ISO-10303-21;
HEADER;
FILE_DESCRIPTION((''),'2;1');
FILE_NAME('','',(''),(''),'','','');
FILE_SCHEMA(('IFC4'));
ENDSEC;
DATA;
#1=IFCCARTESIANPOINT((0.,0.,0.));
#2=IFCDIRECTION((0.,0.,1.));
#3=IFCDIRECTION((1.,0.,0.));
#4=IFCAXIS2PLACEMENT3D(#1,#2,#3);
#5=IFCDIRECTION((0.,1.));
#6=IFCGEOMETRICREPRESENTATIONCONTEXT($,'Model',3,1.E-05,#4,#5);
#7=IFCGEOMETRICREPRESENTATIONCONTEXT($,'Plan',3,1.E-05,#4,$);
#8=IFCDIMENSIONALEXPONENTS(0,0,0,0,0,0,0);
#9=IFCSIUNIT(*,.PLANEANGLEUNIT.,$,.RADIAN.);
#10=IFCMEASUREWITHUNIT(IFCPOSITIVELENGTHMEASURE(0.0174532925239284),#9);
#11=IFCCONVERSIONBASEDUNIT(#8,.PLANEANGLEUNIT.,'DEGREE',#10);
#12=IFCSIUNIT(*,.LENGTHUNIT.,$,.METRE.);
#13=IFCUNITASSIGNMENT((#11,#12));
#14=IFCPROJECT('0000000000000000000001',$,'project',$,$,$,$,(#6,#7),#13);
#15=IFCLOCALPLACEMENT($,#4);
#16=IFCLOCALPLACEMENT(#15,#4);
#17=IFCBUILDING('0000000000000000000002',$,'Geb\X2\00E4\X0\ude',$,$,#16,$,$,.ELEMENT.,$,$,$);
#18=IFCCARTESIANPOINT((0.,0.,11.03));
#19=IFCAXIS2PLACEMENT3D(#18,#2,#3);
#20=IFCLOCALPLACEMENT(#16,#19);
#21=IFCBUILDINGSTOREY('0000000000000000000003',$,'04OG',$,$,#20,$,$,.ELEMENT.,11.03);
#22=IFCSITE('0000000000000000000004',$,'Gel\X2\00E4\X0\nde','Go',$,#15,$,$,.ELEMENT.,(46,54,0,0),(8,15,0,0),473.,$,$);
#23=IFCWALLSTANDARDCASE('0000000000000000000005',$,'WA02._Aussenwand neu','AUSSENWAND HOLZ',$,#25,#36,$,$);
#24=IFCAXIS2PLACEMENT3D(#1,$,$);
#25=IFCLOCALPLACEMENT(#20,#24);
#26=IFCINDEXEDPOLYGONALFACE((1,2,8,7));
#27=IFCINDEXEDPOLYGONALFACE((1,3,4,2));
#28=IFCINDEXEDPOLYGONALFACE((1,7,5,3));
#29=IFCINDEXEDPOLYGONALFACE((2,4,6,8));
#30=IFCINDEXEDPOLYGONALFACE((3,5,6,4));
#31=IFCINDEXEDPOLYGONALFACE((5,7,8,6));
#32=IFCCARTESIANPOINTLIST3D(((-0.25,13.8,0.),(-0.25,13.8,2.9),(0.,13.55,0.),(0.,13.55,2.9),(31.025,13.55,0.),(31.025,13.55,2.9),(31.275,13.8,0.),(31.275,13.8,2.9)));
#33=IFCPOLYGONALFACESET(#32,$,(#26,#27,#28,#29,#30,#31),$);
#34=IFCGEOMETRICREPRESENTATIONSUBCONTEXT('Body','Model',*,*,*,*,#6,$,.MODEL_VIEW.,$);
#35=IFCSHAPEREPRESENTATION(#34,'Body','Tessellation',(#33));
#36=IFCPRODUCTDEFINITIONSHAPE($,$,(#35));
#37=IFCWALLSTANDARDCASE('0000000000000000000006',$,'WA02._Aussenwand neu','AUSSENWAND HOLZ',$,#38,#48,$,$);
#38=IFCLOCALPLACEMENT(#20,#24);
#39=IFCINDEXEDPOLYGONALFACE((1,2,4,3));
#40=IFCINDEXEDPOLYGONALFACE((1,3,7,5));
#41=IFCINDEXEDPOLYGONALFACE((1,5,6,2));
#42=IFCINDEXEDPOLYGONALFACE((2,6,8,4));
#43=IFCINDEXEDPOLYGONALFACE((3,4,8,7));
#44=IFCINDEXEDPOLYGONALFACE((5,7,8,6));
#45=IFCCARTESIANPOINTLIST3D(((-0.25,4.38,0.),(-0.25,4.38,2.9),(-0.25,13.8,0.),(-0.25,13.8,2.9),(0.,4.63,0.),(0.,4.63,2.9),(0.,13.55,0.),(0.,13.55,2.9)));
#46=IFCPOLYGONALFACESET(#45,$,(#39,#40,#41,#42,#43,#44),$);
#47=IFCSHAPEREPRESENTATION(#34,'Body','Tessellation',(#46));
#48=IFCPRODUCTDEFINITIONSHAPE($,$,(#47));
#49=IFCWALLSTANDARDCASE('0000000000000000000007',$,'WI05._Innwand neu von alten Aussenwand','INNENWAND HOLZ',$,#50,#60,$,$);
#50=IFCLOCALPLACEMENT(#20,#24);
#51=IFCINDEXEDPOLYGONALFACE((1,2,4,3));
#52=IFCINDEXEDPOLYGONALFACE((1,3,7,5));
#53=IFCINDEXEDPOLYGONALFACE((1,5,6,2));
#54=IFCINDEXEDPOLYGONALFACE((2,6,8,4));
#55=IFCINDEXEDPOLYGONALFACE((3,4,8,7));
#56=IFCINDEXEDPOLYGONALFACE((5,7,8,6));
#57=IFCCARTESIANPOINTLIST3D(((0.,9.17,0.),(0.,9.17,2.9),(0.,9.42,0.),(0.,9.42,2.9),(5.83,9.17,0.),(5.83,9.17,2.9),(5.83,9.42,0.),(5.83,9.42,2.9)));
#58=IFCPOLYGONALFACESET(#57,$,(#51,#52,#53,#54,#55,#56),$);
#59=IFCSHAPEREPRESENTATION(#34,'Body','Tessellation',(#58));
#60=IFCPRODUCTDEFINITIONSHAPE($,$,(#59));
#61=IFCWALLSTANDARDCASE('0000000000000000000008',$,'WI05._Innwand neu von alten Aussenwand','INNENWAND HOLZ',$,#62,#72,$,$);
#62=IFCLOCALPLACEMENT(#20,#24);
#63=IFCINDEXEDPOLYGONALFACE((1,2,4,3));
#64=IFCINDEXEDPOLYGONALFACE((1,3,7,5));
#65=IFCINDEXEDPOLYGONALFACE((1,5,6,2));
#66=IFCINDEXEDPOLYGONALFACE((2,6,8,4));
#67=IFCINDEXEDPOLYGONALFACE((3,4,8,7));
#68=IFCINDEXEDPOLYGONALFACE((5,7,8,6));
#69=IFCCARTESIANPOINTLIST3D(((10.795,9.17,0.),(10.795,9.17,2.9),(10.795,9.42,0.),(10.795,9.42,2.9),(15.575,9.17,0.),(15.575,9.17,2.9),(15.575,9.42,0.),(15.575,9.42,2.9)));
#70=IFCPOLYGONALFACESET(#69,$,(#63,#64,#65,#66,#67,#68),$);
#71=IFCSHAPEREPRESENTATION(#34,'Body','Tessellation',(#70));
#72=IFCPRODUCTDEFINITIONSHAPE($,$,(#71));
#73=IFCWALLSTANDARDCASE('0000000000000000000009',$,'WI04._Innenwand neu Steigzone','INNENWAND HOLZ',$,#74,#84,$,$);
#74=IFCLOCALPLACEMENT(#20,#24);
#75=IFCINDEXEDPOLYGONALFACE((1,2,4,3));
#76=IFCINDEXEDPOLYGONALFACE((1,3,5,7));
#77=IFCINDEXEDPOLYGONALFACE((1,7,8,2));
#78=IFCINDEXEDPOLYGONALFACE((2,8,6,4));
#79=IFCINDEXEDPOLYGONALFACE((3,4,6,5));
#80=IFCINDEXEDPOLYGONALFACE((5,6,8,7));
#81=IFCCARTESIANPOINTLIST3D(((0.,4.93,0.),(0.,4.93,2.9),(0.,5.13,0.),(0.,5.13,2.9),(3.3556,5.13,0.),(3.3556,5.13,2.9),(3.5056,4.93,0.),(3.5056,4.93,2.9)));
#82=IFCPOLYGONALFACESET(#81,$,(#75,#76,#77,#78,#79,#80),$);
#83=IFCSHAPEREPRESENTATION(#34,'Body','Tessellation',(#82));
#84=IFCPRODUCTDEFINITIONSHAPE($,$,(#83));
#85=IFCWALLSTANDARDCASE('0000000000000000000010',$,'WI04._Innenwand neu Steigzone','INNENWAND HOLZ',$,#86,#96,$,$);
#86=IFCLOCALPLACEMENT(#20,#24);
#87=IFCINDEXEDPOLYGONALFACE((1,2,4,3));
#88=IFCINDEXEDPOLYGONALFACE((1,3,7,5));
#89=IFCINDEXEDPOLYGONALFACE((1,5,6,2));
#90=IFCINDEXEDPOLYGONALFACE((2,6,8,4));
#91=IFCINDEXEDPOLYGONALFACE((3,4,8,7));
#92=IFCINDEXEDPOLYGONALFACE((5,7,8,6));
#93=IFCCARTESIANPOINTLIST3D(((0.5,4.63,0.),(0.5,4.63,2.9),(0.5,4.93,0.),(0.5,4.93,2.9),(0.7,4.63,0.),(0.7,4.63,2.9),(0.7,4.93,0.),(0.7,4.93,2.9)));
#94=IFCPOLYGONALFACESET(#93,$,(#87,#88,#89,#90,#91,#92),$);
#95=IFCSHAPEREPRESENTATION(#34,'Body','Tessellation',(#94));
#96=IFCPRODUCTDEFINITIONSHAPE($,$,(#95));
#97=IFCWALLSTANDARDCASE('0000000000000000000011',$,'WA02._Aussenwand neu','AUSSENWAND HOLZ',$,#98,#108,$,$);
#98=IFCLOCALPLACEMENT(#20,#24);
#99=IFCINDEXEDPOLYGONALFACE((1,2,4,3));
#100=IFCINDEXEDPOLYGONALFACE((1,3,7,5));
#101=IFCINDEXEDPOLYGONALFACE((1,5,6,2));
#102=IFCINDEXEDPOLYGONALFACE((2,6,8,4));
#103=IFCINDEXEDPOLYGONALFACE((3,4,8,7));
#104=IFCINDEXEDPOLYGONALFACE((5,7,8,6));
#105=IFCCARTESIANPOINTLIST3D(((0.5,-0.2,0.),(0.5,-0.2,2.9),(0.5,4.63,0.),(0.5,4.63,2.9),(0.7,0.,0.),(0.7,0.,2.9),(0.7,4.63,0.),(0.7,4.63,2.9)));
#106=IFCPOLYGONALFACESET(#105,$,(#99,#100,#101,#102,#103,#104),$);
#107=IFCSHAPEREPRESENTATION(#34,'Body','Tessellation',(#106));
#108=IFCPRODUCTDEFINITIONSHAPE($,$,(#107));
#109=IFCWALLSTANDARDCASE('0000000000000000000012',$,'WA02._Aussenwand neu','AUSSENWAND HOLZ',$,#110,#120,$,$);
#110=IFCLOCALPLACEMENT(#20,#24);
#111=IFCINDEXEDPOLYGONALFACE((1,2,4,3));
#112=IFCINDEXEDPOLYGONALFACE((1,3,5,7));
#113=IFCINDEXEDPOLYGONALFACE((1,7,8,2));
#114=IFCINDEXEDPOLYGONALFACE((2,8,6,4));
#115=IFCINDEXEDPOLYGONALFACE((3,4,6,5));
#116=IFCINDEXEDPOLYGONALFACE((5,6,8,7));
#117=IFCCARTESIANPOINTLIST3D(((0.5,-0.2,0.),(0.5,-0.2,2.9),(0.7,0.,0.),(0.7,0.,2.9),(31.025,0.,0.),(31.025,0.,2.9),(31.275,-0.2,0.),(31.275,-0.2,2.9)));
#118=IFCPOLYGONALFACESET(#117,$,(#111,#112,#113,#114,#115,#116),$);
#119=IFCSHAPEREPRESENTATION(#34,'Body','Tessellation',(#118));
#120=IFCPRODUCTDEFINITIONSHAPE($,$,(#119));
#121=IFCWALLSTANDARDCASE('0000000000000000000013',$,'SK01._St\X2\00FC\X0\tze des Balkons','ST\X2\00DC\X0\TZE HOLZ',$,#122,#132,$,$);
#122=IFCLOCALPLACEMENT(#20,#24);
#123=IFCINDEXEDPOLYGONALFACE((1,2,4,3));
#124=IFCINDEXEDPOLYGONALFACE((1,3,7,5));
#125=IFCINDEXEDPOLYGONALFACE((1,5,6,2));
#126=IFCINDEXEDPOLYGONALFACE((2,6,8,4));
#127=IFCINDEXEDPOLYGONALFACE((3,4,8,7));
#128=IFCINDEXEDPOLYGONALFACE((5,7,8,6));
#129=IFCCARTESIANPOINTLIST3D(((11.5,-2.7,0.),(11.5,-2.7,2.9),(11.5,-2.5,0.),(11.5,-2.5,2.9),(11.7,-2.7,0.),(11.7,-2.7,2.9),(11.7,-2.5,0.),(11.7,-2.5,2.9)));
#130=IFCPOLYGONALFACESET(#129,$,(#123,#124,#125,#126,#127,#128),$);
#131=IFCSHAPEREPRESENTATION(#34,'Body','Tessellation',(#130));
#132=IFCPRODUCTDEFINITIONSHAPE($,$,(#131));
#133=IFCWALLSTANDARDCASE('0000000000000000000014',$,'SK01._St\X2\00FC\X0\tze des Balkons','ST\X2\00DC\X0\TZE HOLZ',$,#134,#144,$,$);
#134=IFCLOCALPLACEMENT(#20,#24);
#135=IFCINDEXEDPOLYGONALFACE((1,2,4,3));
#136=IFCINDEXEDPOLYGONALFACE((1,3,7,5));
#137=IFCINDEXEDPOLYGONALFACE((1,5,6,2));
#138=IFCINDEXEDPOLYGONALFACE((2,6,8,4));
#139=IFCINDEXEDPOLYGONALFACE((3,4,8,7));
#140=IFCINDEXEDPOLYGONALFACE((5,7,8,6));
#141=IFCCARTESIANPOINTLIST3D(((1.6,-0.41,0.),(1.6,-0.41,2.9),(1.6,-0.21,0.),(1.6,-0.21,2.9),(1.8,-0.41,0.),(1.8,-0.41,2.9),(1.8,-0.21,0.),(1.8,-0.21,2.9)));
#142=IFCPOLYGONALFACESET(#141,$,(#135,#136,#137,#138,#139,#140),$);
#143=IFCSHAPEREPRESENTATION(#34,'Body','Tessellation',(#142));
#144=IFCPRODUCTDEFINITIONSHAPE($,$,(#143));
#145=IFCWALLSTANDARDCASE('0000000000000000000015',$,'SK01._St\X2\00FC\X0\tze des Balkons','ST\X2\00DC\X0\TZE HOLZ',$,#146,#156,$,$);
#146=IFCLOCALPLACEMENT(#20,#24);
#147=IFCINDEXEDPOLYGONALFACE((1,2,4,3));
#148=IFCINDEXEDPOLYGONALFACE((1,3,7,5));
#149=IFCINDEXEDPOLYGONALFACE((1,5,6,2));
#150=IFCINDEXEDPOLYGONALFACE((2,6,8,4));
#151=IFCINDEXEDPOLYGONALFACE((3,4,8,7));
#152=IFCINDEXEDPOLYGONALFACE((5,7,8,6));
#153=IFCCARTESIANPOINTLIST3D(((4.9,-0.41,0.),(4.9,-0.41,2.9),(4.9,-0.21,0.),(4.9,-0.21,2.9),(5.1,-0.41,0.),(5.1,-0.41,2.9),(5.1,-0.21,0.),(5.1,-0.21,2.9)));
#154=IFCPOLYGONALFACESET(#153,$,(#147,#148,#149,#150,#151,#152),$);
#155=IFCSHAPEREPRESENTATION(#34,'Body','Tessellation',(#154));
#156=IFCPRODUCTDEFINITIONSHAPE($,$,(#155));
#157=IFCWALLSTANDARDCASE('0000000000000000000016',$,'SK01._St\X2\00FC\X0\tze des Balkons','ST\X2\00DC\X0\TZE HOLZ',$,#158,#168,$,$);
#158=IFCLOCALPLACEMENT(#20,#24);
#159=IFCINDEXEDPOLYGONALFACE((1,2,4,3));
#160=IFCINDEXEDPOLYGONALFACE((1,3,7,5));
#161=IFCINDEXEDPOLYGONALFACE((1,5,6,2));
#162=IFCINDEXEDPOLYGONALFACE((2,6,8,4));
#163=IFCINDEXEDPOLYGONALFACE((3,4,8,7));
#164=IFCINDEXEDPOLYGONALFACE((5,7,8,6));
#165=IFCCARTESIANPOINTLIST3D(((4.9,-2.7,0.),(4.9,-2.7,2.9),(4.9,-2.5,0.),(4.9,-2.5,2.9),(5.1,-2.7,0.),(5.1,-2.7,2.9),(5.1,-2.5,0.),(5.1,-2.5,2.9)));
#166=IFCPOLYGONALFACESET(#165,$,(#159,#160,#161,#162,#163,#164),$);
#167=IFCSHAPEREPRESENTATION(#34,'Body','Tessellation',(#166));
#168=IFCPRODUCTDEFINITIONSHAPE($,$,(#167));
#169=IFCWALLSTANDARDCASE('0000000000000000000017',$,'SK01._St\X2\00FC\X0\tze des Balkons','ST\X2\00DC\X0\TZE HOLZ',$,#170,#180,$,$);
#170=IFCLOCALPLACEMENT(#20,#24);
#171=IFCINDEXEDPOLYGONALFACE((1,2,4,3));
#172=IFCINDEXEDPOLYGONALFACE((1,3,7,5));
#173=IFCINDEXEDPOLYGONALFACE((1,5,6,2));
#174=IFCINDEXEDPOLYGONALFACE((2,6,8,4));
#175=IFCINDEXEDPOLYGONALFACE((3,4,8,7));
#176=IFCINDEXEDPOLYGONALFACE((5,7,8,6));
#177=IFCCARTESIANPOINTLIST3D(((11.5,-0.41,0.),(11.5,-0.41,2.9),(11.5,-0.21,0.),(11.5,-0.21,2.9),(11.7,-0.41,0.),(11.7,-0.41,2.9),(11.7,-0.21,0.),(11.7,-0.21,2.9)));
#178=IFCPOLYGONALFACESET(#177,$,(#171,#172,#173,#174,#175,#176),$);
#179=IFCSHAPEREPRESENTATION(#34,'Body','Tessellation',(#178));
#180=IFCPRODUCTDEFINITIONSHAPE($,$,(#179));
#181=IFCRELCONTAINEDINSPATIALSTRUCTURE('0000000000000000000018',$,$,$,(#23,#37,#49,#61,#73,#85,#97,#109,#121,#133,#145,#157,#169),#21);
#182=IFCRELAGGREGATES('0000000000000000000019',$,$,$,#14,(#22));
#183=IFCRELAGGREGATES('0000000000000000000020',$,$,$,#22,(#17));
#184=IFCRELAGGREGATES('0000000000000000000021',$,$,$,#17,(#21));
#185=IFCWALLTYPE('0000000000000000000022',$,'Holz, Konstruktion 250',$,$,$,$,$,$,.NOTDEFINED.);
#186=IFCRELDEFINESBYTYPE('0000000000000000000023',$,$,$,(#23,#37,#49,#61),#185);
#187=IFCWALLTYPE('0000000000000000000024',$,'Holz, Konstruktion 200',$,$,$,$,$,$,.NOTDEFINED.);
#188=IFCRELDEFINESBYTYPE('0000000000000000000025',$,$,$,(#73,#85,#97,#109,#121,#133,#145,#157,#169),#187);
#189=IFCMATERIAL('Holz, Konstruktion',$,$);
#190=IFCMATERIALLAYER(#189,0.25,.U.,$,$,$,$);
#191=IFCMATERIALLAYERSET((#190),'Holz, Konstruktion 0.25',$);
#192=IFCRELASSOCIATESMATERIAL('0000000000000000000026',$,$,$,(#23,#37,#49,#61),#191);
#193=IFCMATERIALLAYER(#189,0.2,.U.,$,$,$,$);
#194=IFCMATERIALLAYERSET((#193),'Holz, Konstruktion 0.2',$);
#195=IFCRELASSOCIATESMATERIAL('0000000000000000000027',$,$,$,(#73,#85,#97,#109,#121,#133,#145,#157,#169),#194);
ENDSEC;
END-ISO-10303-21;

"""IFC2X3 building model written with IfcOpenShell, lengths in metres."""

from ifc_helpers import new_model, entity, si_unit, converted_unit, direction, frame, origin_with_axes, place, context, subcontext, project, spatial, polyline, outline, extrude, material, layer, layer_set, layer_usage, type_object, element, save


model = new_model("IFC2X3")

# Units and contexts
model_context = context("Model", 3, precision=1e-05, world=origin_with_axes(), true_north=direction((0.0, 1.0)))
plan_context = context("Plan", 3, precision=1e-05, world=origin_with_axes())
body_context = subcontext(model_context, "Body", "Model", "MODEL_VIEW")
ifc_project = project(units=[converted_unit("PLANEANGLEUNIT", "DEGREE", entity("IfcPositiveLengthMeasure", 0.0174532925239284), si_unit("PLANEANGLEUNIT", "RADIAN"), dimensions=[0, 0, 0, 0, 0, 0, 0]), si_unit("LENGTHUNIT", "METRE")], contexts=[model_context, plan_context])

# Site, building, storey
site_placement = place(None, origin_with_axes())
site = spatial("IfcSite", under=ifc_project, at=site_placement, Name="Gelände", Description="Go", CompositionType="ELEMENT", RefLatitude=(46, 54, 0, 0), RefLongitude=(8, 15, 0, 0), RefElevation=473.0)
building_placement = place(site_placement, origin_with_axes())
building = spatial("IfcBuilding", under=site, at=building_placement, Name="Gebäude", CompositionType="ELEMENT")
storey_placement = place(building_placement, frame((0.0, 0.0, 11.03), z_axis=(0.0, 0.0, 1.0), x_axis=(1.0, 0.0, 0.0)))
storey = spatial("IfcBuildingStorey", under=building, at=storey_placement, Name="04OG", CompositionType="ELEMENT", Elevation=11.03)

# Shared definitions
ifc_material_1 = material(Name="Holz, Konstruktion")

# Walls
ifc_layer_1 = layer(ifc_material_1, 0.25, ventilated="UNKNOWN")
ifc_layer_set_1 = layer_set([ifc_layer_1], Name="Holz, Konstruktion 0.25")
wall_type_1 = type_object("IfcWallType", Name="Holz, Konstruktion 250", PredefinedType="NOTDEFINED")
ifc_layer_usage_1 = layer_usage(ifc_layer_set_1, "AXIS2", "NEGATIVE", 0.0)
wall_1_placement = place(storey_placement, frame((-0.25, 13.8, 0.0), z_axis=(0.0, 0.0, 1.0), x_axis=(1.0, 0.0, 0.0)))
element("IfcWallStandardCase", 1, at=wall_1_placement, inside=storey, type_object=wall_type_1, material=ifc_layer_usage_1, Name="WA02._Aussenwand neu", Description="AUSSENWAND HOLZ", context=body_context, shape_type="SweptSolid", body=[
    extrude(outline(polyline([(0.25, -0.25), (31.275, -0.25), (31.525, 0.0), (0.0, 0.0), (0.25, -0.25)])), origin_with_axes(), (0.0, 0.0, 1.0), 2.9),
])
ifc_layer_usage_2 = layer_usage(ifc_layer_set_1, "AXIS2", "NEGATIVE", 0.0)
wall_2_placement = place(storey_placement, frame((-0.25, 4.38, 0.0), z_axis=(0.0, 0.0, 1.0), x_axis=(0.0, 1.0, 0.0)))
element("IfcWallStandardCase", 2, at=wall_2_placement, inside=storey, type_object=wall_type_1, material=ifc_layer_usage_2, Name="WA02._Aussenwand neu", Description="AUSSENWAND HOLZ", context=body_context, shape_type="SweptSolid", body=[
    extrude(outline(polyline([(0.25, -0.25), (9.17, -0.25), (9.42, 0.0), (0.0, 0.0), (0.25, -0.25)])), origin_with_axes(), (0.0, 0.0, 1.0), 2.9),
])
ifc_layer_usage_3 = layer_usage(ifc_layer_set_1, "AXIS2", "NEGATIVE", 0.0)
wall_3_placement = place(storey_placement, frame((0.0, 9.42, 0.0), z_axis=(0.0, 0.0, 1.0), x_axis=(1.0, 0.0, 0.0)))
element("IfcWallStandardCase", 3, at=wall_3_placement, inside=storey, type_object=wall_type_1, material=ifc_layer_usage_3, Name="WI05._Innwand neu von alten Aussenwand", Description="INNENWAND HOLZ", context=body_context, shape_type="SweptSolid", body=[
    extrude(outline(polyline([(0.0, -0.25), (5.83, -0.25), (5.83, 0.0), (0.0, 0.0), (0.0, -0.25)])), origin_with_axes(), (0.0, 0.0, 1.0), 2.9),
])
ifc_layer_usage_4 = layer_usage(ifc_layer_set_1, "AXIS2", "NEGATIVE", 0.0)
wall_4_placement = place(storey_placement, frame((10.795, 9.42, 0.0), z_axis=(0.0, 0.0, 1.0), x_axis=(1.0, 0.0, 0.0)))
element("IfcWallStandardCase", 4, at=wall_4_placement, inside=storey, type_object=wall_type_1, material=ifc_layer_usage_4, Name="WI05._Innwand neu von alten Aussenwand", Description="INNENWAND HOLZ", context=body_context, shape_type="SweptSolid", body=[
    extrude(outline(polyline([(0.0, -0.25), (4.78, -0.25), (4.78, 0.0), (0.0, 0.0), (0.0, -0.25)])), origin_with_axes(), (0.0, 0.0, 1.0), 2.9),
])
ifc_layer_2 = layer(ifc_material_1, 0.2, ventilated="UNKNOWN")
ifc_layer_set_2 = layer_set([ifc_layer_2], Name="Holz, Konstruktion 0.2")
ifc_layer_usage_5 = layer_usage(ifc_layer_set_2, "AXIS2", "NEGATIVE", 0.0)
wall_type_2 = type_object("IfcWallType", Name="Holz, Konstruktion 200", PredefinedType="NOTDEFINED")
wall_5_placement = place(storey_placement, frame((3.5056, 4.93, 0.0), z_axis=(0.0, 0.0, 1.0), x_axis=(-1.0, 0.0, 0.0)))
element("IfcWallStandardCase", 5, at=wall_5_placement, inside=storey, type_object=wall_type_2, material=ifc_layer_usage_5, Name="WI04._Innenwand neu Steigzone", Description="INNENWAND HOLZ", context=body_context, shape_type="SweptSolid", body=[
    extrude(outline(polyline([(0.15, -0.2), (3.5056, -0.2), (3.5056, 0.0), (0.0, 0.0), (0.15, -0.2)])), origin_with_axes(), (0.0, 0.0, 1.0), 2.9),
])
ifc_layer_usage_6 = layer_usage(ifc_layer_set_2, "AXIS2", "NEGATIVE", 0.0)
wall_6_placement = place(storey_placement, frame((0.7, 4.93, 0.0), z_axis=(0.0, 0.0, 1.0), x_axis=(0.0, -1.0, 0.0)))
element("IfcWallStandardCase", 6, at=wall_6_placement, inside=storey, type_object=wall_type_2, material=ifc_layer_usage_6, Name="WI04._Innenwand neu Steigzone", Description="INNENWAND HOLZ", context=body_context, shape_type="SweptSolid", body=[
    extrude(outline(polyline([(0.0, -0.2), (0.3, -0.2), (0.3, 0.0), (0.0, 0.0), (0.0, -0.2)])), origin_with_axes(), (0.0, 0.0, 1.0), 2.9),
])
ifc_layer_usage_7 = layer_usage(ifc_layer_set_2, "AXIS2", "POSITIVE", 0.0)
wall_7_placement = place(storey_placement, frame((0.5, 4.63, 0.0), z_axis=(0.0, 0.0, 1.0), x_axis=(0.0, -1.0, 0.0)))
element("IfcWallStandardCase", 7, at=wall_7_placement, inside=storey, type_object=wall_type_2, material=ifc_layer_usage_7, Name="WA02._Aussenwand neu", Description="AUSSENWAND HOLZ", context=body_context, shape_type="SweptSolid", body=[
    extrude(outline(polyline([(0.0, 0.0), (4.83, 0.0), (4.63, 0.2), (0.0, 0.2), (0.0, 0.0)])), origin_with_axes(), (0.0, 0.0, 1.0), 2.9),
])
ifc_layer_usage_8 = layer_usage(ifc_layer_set_2, "AXIS2", "POSITIVE", 0.0)
wall_8_placement = place(storey_placement, frame((0.5, -0.2, 0.0), z_axis=(0.0, 0.0, 1.0), x_axis=(1.0, 0.0, 0.0)))
element("IfcWallStandardCase", 8, at=wall_8_placement, inside=storey, type_object=wall_type_2, material=ifc_layer_usage_8, Name="WA02._Aussenwand neu", Description="AUSSENWAND HOLZ", context=body_context, shape_type="SweptSolid", body=[
    extrude(outline(polyline([(0.0, 0.0), (30.775, 0.0), (30.525, 0.2), (0.2, 0.2), (0.0, 0.0)])), origin_with_axes(), (0.0, 0.0, 1.0), 2.9),
])
ifc_layer_usage_9 = layer_usage(ifc_layer_set_2, "AXIS2", "NEGATIVE", 0.0)
wall_9_placement = place(storey_placement, frame((11.5, -2.7, 0.0), z_axis=(0.0, 0.0, 1.0), x_axis=(0.0, 1.0, 0.0)))
element("IfcWallStandardCase", 9, at=wall_9_placement, inside=storey, type_object=wall_type_2, material=ifc_layer_usage_9, Name="SK01._Stütze des Balkons", Description="STÜTZE HOLZ", context=body_context, shape_type="SweptSolid", body=[
    extrude(outline(polyline([(0.0, -0.2), (0.2, -0.2), (0.2, 0.0), (0.0, 0.0), (0.0, -0.2)])), origin_with_axes(), (0.0, 0.0, 1.0), 2.9),
])
ifc_layer_usage_10 = layer_usage(ifc_layer_set_2, "AXIS2", "NEGATIVE", 0.0)
wall_10_placement = place(storey_placement, frame((1.6, -0.41, 0.0), z_axis=(0.0, 0.0, 1.0), x_axis=(0.0, 1.0, 0.0)))
element("IfcWallStandardCase", 10, at=wall_10_placement, inside=storey, type_object=wall_type_2, material=ifc_layer_usage_10, Name="SK01._Stütze des Balkons", Description="STÜTZE HOLZ", context=body_context, shape_type="SweptSolid", body=[
    extrude(outline(polyline([(0.0, -0.2), (0.2, -0.2), (0.2, 0.0), (0.0, 0.0), (0.0, -0.2)])), origin_with_axes(), (0.0, 0.0, 1.0), 2.9),
])
ifc_layer_usage_11 = layer_usage(ifc_layer_set_2, "AXIS2", "POSITIVE", 0.0)
wall_11_placement = place(storey_placement, frame((5.1, -0.41, 0.0), z_axis=(0.0, 0.0, 1.0), x_axis=(0.0, 1.0, 0.0)))
element("IfcWallStandardCase", 11, at=wall_11_placement, inside=storey, type_object=wall_type_2, material=ifc_layer_usage_11, Name="SK01._Stütze des Balkons", Description="STÜTZE HOLZ", context=body_context, shape_type="SweptSolid", body=[
    extrude(outline(polyline([(0.0, 0.0), (0.2, 0.0), (0.2, 0.2), (0.0, 0.2), (0.0, 0.0)])), origin_with_axes(), (0.0, 0.0, 1.0), 2.9),
])
ifc_layer_usage_12 = layer_usage(ifc_layer_set_2, "AXIS2", "POSITIVE", 0.0)
wall_12_placement = place(storey_placement, frame((5.1, -2.7, 0.0), z_axis=(0.0, 0.0, 1.0), x_axis=(0.0, 1.0, 0.0)))
element("IfcWallStandardCase", 12, at=wall_12_placement, inside=storey, type_object=wall_type_2, material=ifc_layer_usage_12, Name="SK01._Stütze des Balkons", Description="STÜTZE HOLZ", context=body_context, shape_type="SweptSolid", body=[
    extrude(outline(polyline([(0.0, 0.0), (0.2, 0.0), (0.2, 0.2), (0.0, 0.2), (0.0, 0.0)])), origin_with_axes(), (0.0, 0.0, 1.0), 2.9),
])
ifc_layer_usage_13 = layer_usage(ifc_layer_set_2, "AXIS2", "NEGATIVE", 0.0)
wall_13_placement = place(storey_placement, frame((11.5, -0.41, 0.0), z_axis=(0.0, 0.0, 1.0), x_axis=(0.0, 1.0, 0.0)))
element("IfcWallStandardCase", 13, at=wall_13_placement, inside=storey, type_object=wall_type_2, material=ifc_layer_usage_13, Name="SK01._Stütze des Balkons", Description="STÜTZE HOLZ", context=body_context, shape_type="SweptSolid", body=[
    extrude(outline(polyline([(0.0, -0.2), (0.2, -0.2), (0.2, 0.0), (0.0, 0.0), (0.0, -0.2)])), origin_with_axes(), (0.0, 0.0, 1.0), 2.9),
])

save(model, "model.ifc")
